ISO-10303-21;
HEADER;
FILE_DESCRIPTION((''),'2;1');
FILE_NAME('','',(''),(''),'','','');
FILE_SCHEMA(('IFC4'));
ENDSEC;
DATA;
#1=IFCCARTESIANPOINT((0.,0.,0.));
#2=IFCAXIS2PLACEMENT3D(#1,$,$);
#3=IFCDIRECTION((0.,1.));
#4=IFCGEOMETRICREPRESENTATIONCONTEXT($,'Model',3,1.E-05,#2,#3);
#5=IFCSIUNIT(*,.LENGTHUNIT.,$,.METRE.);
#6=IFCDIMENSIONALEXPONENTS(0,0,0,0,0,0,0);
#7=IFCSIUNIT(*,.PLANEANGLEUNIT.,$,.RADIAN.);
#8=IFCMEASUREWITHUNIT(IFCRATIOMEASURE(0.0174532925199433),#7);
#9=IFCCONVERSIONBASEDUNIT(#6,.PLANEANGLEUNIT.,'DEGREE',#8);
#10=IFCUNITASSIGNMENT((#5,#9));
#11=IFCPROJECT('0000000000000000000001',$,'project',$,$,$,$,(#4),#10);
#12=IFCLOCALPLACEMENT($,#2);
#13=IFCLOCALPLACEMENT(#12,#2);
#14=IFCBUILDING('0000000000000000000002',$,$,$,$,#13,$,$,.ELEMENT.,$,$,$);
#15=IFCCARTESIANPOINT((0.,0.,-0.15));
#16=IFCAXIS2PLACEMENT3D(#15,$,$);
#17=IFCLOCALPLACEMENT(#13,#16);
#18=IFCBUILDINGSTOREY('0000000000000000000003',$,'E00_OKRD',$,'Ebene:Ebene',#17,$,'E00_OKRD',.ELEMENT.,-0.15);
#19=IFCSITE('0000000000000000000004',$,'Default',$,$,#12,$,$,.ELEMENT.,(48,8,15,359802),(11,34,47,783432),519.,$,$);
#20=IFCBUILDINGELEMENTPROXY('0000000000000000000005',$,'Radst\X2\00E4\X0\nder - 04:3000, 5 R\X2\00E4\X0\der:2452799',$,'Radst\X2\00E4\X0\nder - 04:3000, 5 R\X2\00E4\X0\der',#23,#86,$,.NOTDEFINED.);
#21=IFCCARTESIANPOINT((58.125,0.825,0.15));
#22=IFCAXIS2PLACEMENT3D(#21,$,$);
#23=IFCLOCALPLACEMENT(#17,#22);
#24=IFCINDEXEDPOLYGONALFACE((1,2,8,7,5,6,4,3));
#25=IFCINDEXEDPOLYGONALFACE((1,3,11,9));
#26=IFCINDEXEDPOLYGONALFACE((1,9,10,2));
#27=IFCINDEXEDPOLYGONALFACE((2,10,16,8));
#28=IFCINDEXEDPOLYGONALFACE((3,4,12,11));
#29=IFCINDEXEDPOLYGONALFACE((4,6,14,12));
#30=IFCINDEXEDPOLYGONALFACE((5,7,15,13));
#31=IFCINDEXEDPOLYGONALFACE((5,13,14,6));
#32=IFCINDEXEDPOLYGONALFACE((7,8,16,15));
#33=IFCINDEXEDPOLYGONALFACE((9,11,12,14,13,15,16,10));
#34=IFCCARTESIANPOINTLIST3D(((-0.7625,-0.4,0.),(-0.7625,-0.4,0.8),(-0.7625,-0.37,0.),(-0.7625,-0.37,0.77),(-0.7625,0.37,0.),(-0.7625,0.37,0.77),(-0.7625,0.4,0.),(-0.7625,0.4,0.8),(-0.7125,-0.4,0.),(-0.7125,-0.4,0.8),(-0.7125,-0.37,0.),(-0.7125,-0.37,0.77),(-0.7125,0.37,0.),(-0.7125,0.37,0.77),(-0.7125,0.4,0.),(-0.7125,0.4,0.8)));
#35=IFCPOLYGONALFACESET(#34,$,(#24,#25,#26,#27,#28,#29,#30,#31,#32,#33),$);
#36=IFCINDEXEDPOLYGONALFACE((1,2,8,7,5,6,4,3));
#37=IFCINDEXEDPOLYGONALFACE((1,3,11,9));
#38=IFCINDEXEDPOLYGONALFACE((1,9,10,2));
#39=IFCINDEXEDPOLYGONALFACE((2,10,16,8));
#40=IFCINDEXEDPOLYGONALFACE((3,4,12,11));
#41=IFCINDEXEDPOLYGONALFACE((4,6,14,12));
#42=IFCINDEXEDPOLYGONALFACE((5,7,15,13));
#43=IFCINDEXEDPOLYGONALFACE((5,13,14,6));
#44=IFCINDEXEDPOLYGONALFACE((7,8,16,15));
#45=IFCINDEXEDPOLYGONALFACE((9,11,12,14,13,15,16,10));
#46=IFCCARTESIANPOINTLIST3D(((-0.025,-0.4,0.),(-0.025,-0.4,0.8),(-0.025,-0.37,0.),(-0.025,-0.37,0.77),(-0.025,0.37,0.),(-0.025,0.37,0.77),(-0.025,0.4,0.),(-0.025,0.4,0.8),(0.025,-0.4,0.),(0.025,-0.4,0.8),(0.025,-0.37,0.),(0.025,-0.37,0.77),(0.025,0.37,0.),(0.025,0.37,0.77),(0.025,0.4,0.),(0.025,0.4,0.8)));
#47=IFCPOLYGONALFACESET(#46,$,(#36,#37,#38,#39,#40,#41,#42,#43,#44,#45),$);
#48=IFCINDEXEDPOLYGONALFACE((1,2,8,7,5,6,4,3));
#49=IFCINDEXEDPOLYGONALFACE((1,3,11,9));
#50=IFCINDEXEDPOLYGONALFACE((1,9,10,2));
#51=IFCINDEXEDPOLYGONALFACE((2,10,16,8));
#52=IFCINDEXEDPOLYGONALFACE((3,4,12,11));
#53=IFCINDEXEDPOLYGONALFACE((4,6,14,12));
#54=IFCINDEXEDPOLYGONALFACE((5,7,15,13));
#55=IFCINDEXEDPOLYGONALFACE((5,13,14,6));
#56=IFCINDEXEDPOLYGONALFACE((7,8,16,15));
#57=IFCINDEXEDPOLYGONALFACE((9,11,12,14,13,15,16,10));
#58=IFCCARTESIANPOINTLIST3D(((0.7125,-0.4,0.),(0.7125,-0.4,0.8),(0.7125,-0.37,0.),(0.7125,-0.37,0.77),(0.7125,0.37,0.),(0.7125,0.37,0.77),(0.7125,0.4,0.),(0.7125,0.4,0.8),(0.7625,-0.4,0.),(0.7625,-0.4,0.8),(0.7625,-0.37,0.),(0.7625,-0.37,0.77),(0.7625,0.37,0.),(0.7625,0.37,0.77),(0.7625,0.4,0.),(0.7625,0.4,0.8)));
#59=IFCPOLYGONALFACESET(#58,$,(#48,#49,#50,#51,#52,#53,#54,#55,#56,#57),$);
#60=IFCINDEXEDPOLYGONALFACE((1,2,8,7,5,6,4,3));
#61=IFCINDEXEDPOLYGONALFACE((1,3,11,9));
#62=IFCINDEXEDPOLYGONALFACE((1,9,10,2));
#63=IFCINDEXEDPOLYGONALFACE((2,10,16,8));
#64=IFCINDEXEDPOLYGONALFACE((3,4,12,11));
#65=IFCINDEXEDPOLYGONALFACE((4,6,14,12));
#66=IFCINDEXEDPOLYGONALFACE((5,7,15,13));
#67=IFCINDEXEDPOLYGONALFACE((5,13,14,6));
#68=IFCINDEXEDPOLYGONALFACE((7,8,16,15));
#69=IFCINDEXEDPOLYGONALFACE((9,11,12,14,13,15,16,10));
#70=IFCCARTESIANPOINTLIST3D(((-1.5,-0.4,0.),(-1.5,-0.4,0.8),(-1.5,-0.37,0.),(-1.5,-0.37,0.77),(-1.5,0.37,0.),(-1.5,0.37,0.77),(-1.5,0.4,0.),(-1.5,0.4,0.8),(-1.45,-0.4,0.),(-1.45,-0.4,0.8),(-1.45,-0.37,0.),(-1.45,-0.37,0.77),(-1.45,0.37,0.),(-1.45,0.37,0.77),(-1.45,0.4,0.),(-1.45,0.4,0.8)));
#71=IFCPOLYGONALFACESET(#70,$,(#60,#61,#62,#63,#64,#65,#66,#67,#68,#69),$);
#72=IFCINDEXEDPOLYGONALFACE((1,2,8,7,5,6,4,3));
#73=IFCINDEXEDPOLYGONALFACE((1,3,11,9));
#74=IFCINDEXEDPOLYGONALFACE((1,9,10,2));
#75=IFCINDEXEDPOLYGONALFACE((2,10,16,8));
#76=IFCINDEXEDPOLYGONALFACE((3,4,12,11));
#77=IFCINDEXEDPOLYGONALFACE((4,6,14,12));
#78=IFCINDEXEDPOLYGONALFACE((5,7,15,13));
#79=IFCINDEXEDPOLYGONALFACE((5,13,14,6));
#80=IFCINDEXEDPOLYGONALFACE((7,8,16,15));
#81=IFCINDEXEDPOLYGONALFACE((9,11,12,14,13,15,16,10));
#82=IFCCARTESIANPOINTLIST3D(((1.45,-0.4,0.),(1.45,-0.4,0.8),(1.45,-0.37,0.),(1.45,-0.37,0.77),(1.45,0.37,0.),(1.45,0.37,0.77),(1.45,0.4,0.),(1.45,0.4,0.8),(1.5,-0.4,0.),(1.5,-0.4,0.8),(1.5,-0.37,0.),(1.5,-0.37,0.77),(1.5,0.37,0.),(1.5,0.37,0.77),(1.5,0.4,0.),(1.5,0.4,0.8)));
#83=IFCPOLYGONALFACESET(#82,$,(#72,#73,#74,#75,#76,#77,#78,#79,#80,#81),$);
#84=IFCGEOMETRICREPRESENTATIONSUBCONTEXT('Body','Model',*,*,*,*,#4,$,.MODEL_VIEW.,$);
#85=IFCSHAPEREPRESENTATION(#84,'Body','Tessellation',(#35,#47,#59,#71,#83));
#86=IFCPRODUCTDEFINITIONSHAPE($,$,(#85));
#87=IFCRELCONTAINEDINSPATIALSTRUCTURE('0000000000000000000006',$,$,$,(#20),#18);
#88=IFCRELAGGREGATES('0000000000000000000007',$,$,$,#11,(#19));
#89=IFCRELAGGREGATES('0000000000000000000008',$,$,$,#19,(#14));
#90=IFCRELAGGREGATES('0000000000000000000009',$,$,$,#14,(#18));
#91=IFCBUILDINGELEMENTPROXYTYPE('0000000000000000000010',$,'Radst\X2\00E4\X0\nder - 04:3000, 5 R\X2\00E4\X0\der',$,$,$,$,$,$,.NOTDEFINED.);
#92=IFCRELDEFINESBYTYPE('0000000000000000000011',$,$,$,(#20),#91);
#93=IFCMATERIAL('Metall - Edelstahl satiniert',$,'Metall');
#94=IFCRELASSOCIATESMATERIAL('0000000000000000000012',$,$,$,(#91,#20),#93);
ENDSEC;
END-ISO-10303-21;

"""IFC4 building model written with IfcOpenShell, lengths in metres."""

from ifc_helpers import new_model, entity, si_unit, converted_unit, direction, frame, origin, place, context, subcontext, project, spatial, polyline, outline, extrude, source, transform, mapped, material, type_object, type_shapes, element, save


model = new_model("IFC4")

# Units and contexts
model_context = context("Model", 3, precision=1e-05, world=origin(), true_north=direction((0.0, 1.0)))
body_context = subcontext(model_context, "Body", "Model", "MODEL_VIEW")
ifc_project = project(units=[si_unit("LENGTHUNIT", "METRE"), converted_unit("PLANEANGLEUNIT", "DEGREE", entity("IfcRatioMeasure", 0.0174532925199433), si_unit("PLANEANGLEUNIT", "RADIAN"), dimensions=[0, 0, 0, 0, 0, 0, 0])], contexts=[model_context])

# Site, building, storey
site_placement = place(None, frame((0.0, 0.0, 0.0)))
site = spatial("IfcSite", under=ifc_project, at=site_placement, Name="Default", CompositionType="ELEMENT", RefLatitude=(48, 8, 15, 359802), RefLongitude=(11, 34, 47, 783432), RefElevation=519.0)
building_placement = place(site_placement, origin())
building = spatial("IfcBuilding", under=site, at=building_placement, CompositionType="ELEMENT")
storey_placement = place(building_placement, frame((0.0, 0.0, -0.15)))
storey = spatial("IfcBuildingStorey", under=building, at=storey_placement, Name="E00_OKRD", ObjectType="Ebene:Ebene", LongName="E00_OKRD", CompositionType="ELEMENT", Elevation=-0.15)

# Building element proxy
ifc_material_1 = material(Name="Metall - Edelstahl satiniert", Category="Metall")
building_element_proxy_type_1 = type_object("IfcBuildingElementProxyType", Name="Radständer - 04:3000, 5 Räder", PredefinedType="NOTDEFINED", material=ifc_material_1)
shared_shape_1 = source(origin(), body_context, "Body", "SweptSolid", [
    extrude(outline(polyline([(-0.4075, -0.4), (0.3925, -0.4), (0.3925, -0.37), (-0.3775, -0.37), (-0.3775, 0.37), (0.3925, 0.37), (0.3925, 0.4), (-0.4075, 0.4), (-0.4075, -0.4)])), frame((-0.7625, 0.0, 0.3925), z_axis=(1.0, 0.0, 0.0), x_axis=(0.0, 0.0, -1.0)), (0.0, 0.0, 1.0), 0.05),
    extrude(outline(polyline([(-0.4075, -0.4), (0.3925, -0.4), (0.3925, -0.37), (-0.3775, -0.37), (-0.3775, 0.37), (0.3925, 0.37), (0.3925, 0.4), (-0.4075, 0.4), (-0.4075, -0.4)])), frame((-0.025, 0.0, 0.3925), z_axis=(1.0, 0.0, 0.0), x_axis=(0.0, 0.0, -1.0)), (0.0, 0.0, 1.0), 0.05),
    extrude(outline(polyline([(-0.4075, -0.4), (0.3925, -0.4), (0.3925, -0.37), (-0.3775, -0.37), (-0.3775, 0.37), (0.3925, 0.37), (0.3925, 0.4), (-0.4075, 0.4), (-0.4075, -0.4)])), frame((0.7125, 0.0, 0.3925), z_axis=(1.0, 0.0, 0.0), x_axis=(0.0, 0.0, -1.0)), (0.0, 0.0, 1.0), 0.05),
    extrude(outline(polyline([(-0.4075, -0.4), (0.3925, -0.4), (0.3925, -0.37), (-0.3775, -0.37), (-0.3775, 0.37), (0.3925, 0.37), (0.3925, 0.4), (-0.4075, 0.4), (-0.4075, -0.4)])), frame((-1.5, 0.0, 0.3925), z_axis=(1.0, 0.0, 0.0), x_axis=(0.0, 0.0, -1.0)), (0.0, 0.0, 1.0), 0.05),
    extrude(outline(polyline([(-0.4075, -0.4), (0.3925, -0.4), (0.3925, -0.37), (-0.3775, -0.37), (-0.3775, 0.37), (0.3925, 0.37), (0.3925, 0.4), (-0.4075, 0.4), (-0.4075, -0.4)])), frame((1.45, 0.0, 0.3925), z_axis=(1.0, 0.0, 0.0), x_axis=(0.0, 0.0, -1.0)), (0.0, 0.0, 1.0), 0.05),
])
type_shapes(building_element_proxy_type_1, [shared_shape_1])
for number, where, name in (
    (1, (58.125, 0.825, 0.15), "Radständer - 04:3000, 5 Räder:2452799"),
):
    element("IfcBuildingElementProxy", number, at=place(storey_placement, frame(where)), inside=storey, type_object=building_element_proxy_type_1, material=ifc_material_1, Name=name, ObjectType="Radständer - 04:3000, 5 Räder", PredefinedType="NOTDEFINED", context=body_context, shape_type="MappedRepresentation", body=[
        mapped(shared_shape_1, transform((0.0, 0.0, 0.0), scale=1.0)),
    ])

save(model, "model.ifc")
